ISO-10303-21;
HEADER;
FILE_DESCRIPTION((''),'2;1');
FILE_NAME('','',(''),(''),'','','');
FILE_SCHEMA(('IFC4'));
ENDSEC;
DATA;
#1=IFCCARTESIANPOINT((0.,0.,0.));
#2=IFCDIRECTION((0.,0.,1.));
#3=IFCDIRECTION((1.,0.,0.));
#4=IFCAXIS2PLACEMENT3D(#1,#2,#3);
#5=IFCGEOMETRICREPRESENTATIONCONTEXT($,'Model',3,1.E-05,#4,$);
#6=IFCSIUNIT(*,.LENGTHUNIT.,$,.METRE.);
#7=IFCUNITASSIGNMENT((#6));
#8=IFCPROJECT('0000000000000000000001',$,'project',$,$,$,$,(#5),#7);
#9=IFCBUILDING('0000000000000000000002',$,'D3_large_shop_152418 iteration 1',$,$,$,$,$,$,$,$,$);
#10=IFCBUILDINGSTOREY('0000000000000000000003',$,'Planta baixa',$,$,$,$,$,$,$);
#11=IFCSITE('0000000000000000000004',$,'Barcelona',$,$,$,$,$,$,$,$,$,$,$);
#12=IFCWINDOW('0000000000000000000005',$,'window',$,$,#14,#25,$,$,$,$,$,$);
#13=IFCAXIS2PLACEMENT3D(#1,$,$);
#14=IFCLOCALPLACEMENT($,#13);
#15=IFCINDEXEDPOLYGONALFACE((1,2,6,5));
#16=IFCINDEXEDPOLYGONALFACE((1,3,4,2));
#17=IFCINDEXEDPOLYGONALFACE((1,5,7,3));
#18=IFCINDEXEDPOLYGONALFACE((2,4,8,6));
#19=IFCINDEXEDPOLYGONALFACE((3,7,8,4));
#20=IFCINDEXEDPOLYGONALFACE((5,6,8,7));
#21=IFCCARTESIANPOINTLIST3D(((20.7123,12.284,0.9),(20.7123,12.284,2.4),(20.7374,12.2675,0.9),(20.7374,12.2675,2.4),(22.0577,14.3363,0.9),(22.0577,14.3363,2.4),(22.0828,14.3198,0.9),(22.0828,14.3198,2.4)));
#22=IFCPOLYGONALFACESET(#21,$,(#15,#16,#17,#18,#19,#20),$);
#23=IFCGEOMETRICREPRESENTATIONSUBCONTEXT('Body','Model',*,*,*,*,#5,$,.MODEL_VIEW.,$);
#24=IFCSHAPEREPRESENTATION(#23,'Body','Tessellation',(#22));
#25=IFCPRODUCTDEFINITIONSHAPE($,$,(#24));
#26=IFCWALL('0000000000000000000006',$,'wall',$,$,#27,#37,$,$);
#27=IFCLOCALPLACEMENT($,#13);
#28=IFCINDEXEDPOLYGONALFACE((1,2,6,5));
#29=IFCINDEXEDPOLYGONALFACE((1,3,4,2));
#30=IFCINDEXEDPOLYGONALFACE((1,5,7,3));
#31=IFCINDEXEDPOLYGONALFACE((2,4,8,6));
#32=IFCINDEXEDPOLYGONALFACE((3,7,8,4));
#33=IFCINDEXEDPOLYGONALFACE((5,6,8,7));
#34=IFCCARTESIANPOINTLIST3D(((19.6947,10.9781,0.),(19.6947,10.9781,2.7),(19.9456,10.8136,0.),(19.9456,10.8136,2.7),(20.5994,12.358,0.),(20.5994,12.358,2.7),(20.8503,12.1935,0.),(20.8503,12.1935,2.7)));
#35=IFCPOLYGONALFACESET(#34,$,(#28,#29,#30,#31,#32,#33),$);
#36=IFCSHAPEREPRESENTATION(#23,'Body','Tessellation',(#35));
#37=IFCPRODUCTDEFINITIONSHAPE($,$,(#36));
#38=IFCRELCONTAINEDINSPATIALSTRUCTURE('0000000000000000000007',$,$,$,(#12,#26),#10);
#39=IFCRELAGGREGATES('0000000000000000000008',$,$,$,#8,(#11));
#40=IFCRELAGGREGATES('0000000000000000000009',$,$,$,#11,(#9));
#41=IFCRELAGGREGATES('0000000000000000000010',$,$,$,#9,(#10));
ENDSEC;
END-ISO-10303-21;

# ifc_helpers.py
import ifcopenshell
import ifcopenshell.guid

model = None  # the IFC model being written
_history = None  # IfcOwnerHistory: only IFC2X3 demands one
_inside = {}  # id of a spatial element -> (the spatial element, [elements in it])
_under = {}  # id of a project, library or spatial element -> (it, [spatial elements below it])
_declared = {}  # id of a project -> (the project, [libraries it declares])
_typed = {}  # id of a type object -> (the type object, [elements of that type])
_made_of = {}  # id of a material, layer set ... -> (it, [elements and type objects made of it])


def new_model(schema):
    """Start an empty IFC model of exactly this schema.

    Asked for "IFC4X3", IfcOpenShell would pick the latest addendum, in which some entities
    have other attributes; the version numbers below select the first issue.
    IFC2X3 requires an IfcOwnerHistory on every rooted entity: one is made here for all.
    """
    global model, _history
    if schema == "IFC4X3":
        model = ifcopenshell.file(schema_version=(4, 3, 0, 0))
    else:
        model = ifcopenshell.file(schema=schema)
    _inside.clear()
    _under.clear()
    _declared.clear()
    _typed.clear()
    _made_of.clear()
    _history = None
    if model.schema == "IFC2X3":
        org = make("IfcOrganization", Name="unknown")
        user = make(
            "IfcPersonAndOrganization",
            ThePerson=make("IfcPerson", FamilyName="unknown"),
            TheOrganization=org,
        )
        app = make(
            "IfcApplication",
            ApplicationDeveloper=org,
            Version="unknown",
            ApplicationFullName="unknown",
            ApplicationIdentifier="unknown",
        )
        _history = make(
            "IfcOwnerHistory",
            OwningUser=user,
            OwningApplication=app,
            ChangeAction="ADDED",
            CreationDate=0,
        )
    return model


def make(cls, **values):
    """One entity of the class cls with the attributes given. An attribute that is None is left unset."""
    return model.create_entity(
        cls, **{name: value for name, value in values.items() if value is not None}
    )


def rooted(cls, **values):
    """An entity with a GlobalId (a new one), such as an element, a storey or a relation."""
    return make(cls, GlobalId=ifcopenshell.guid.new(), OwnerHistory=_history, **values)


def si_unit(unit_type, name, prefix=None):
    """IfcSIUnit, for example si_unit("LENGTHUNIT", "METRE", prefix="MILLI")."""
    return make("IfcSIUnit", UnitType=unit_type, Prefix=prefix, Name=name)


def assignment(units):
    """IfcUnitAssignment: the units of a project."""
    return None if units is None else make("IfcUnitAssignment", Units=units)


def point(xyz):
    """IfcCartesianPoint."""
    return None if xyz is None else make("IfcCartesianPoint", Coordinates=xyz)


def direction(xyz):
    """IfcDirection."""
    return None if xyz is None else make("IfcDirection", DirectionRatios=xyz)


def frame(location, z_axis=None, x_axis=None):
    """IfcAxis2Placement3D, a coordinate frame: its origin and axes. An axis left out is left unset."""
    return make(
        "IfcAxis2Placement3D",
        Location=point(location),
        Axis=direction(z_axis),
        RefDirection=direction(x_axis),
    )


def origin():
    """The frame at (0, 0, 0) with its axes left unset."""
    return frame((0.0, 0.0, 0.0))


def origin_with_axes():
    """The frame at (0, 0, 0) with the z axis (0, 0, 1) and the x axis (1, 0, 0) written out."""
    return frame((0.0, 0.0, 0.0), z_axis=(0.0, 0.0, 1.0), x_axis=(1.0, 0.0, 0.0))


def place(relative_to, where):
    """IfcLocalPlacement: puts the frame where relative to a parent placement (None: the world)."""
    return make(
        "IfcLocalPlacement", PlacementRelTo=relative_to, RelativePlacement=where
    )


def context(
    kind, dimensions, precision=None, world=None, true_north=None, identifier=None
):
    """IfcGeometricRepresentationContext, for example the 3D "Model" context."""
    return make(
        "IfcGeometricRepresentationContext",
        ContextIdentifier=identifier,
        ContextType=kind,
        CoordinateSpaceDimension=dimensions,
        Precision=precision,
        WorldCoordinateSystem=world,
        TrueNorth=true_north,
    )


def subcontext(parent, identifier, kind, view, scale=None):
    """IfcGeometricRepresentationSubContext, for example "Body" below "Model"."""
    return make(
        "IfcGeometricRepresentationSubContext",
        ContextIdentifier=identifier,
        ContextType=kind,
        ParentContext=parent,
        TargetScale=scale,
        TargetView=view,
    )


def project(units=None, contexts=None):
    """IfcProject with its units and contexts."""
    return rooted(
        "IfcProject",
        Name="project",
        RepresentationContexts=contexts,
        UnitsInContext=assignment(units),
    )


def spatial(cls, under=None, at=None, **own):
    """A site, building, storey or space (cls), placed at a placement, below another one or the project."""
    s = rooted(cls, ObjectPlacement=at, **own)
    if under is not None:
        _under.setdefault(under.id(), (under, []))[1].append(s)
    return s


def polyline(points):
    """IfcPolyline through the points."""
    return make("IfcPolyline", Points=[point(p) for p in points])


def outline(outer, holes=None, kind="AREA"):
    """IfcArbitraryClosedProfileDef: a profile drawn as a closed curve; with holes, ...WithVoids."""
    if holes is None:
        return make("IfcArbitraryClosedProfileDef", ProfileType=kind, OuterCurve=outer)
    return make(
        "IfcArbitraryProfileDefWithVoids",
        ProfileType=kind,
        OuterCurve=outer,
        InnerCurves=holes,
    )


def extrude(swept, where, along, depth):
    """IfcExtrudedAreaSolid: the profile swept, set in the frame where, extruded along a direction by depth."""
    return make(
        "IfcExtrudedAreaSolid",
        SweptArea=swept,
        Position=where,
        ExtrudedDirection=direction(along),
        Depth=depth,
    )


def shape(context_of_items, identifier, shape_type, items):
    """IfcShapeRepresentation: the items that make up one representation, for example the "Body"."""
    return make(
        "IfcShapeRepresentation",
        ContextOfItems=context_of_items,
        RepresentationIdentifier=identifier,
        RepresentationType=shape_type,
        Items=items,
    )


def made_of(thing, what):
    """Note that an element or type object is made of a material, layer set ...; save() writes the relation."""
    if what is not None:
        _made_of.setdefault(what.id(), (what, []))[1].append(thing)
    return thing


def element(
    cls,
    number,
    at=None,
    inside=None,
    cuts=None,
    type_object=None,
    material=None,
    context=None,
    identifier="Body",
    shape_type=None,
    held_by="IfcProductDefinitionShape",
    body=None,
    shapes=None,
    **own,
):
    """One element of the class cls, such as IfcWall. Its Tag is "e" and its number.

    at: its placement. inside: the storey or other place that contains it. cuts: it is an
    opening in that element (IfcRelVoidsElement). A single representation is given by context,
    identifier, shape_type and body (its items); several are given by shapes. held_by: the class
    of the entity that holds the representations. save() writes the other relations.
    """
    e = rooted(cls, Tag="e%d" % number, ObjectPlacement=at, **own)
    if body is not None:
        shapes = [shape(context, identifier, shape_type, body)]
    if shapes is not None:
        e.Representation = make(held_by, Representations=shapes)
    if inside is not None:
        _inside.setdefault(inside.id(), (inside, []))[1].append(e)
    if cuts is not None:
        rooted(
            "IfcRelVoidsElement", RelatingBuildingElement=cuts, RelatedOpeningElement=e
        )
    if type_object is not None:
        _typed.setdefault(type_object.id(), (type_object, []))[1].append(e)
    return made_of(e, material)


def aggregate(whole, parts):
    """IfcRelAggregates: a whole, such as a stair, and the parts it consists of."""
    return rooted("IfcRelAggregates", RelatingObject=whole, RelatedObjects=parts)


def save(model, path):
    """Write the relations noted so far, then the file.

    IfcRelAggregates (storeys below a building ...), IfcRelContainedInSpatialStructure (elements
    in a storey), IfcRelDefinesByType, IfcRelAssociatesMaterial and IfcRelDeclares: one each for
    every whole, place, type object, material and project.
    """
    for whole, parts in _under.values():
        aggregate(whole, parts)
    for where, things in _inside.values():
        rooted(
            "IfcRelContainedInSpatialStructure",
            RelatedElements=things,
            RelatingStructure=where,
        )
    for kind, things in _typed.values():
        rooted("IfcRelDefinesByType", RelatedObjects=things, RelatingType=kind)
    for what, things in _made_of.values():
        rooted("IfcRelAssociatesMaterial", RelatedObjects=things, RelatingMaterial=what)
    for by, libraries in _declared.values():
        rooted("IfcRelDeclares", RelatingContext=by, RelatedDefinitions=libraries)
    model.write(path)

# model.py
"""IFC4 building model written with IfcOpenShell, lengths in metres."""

from ifc_helpers import new_model, si_unit, frame, origin, origin_with_axes, place, context, subcontext, project, spatial, polyline, outline, extrude, element, save


model = new_model("IFC4")

# Units and contexts
model_context = context("Model", 3, precision=1e-05, world=origin_with_axes())
body_context = subcontext(model_context, "Body", "Model", "MODEL_VIEW")
ifc_project = project(units=[si_unit("LENGTHUNIT", "METRE")], contexts=[model_context])

# Site, building, storey
site = spatial("IfcSite", under=ifc_project, Name="Barcelona")
building = spatial("IfcBuilding", under=site, Name="D3_large_shop_152418 iteration 1")
storey = spatial("IfcBuildingStorey", under=building, Name="Planta baixa")

# Window
window_1_placement = place(None, origin_with_axes())
element("IfcWindow", 1, at=window_1_placement, inside=storey, Name="window", context=body_context, shape_type="SweptSolid", body=[
    extrude(outline(polyline([(22.0828, 14.3198), (20.7374, 12.2675), (20.7123, 12.284), (22.0577, 14.3363), (22.0828, 14.3198)])), frame((0.0, 0.0, 0.9)), (0.0, 0.0, 1.0), 1.5),
])

# Wall
wall_1_placement = place(None, origin_with_axes())
element("IfcWall", 2, at=wall_1_placement, inside=storey, Name="wall", context=body_context, shape_type="SweptSolid", body=[
    extrude(outline(polyline([(20.8503, 12.1935), (19.9456, 10.8136), (19.6947, 10.9781), (20.5994, 12.358), (20.8503, 12.1935)])), origin(), (0.0, 0.0, 1.0), 2.7),
])

save(model, "model.ifc")
